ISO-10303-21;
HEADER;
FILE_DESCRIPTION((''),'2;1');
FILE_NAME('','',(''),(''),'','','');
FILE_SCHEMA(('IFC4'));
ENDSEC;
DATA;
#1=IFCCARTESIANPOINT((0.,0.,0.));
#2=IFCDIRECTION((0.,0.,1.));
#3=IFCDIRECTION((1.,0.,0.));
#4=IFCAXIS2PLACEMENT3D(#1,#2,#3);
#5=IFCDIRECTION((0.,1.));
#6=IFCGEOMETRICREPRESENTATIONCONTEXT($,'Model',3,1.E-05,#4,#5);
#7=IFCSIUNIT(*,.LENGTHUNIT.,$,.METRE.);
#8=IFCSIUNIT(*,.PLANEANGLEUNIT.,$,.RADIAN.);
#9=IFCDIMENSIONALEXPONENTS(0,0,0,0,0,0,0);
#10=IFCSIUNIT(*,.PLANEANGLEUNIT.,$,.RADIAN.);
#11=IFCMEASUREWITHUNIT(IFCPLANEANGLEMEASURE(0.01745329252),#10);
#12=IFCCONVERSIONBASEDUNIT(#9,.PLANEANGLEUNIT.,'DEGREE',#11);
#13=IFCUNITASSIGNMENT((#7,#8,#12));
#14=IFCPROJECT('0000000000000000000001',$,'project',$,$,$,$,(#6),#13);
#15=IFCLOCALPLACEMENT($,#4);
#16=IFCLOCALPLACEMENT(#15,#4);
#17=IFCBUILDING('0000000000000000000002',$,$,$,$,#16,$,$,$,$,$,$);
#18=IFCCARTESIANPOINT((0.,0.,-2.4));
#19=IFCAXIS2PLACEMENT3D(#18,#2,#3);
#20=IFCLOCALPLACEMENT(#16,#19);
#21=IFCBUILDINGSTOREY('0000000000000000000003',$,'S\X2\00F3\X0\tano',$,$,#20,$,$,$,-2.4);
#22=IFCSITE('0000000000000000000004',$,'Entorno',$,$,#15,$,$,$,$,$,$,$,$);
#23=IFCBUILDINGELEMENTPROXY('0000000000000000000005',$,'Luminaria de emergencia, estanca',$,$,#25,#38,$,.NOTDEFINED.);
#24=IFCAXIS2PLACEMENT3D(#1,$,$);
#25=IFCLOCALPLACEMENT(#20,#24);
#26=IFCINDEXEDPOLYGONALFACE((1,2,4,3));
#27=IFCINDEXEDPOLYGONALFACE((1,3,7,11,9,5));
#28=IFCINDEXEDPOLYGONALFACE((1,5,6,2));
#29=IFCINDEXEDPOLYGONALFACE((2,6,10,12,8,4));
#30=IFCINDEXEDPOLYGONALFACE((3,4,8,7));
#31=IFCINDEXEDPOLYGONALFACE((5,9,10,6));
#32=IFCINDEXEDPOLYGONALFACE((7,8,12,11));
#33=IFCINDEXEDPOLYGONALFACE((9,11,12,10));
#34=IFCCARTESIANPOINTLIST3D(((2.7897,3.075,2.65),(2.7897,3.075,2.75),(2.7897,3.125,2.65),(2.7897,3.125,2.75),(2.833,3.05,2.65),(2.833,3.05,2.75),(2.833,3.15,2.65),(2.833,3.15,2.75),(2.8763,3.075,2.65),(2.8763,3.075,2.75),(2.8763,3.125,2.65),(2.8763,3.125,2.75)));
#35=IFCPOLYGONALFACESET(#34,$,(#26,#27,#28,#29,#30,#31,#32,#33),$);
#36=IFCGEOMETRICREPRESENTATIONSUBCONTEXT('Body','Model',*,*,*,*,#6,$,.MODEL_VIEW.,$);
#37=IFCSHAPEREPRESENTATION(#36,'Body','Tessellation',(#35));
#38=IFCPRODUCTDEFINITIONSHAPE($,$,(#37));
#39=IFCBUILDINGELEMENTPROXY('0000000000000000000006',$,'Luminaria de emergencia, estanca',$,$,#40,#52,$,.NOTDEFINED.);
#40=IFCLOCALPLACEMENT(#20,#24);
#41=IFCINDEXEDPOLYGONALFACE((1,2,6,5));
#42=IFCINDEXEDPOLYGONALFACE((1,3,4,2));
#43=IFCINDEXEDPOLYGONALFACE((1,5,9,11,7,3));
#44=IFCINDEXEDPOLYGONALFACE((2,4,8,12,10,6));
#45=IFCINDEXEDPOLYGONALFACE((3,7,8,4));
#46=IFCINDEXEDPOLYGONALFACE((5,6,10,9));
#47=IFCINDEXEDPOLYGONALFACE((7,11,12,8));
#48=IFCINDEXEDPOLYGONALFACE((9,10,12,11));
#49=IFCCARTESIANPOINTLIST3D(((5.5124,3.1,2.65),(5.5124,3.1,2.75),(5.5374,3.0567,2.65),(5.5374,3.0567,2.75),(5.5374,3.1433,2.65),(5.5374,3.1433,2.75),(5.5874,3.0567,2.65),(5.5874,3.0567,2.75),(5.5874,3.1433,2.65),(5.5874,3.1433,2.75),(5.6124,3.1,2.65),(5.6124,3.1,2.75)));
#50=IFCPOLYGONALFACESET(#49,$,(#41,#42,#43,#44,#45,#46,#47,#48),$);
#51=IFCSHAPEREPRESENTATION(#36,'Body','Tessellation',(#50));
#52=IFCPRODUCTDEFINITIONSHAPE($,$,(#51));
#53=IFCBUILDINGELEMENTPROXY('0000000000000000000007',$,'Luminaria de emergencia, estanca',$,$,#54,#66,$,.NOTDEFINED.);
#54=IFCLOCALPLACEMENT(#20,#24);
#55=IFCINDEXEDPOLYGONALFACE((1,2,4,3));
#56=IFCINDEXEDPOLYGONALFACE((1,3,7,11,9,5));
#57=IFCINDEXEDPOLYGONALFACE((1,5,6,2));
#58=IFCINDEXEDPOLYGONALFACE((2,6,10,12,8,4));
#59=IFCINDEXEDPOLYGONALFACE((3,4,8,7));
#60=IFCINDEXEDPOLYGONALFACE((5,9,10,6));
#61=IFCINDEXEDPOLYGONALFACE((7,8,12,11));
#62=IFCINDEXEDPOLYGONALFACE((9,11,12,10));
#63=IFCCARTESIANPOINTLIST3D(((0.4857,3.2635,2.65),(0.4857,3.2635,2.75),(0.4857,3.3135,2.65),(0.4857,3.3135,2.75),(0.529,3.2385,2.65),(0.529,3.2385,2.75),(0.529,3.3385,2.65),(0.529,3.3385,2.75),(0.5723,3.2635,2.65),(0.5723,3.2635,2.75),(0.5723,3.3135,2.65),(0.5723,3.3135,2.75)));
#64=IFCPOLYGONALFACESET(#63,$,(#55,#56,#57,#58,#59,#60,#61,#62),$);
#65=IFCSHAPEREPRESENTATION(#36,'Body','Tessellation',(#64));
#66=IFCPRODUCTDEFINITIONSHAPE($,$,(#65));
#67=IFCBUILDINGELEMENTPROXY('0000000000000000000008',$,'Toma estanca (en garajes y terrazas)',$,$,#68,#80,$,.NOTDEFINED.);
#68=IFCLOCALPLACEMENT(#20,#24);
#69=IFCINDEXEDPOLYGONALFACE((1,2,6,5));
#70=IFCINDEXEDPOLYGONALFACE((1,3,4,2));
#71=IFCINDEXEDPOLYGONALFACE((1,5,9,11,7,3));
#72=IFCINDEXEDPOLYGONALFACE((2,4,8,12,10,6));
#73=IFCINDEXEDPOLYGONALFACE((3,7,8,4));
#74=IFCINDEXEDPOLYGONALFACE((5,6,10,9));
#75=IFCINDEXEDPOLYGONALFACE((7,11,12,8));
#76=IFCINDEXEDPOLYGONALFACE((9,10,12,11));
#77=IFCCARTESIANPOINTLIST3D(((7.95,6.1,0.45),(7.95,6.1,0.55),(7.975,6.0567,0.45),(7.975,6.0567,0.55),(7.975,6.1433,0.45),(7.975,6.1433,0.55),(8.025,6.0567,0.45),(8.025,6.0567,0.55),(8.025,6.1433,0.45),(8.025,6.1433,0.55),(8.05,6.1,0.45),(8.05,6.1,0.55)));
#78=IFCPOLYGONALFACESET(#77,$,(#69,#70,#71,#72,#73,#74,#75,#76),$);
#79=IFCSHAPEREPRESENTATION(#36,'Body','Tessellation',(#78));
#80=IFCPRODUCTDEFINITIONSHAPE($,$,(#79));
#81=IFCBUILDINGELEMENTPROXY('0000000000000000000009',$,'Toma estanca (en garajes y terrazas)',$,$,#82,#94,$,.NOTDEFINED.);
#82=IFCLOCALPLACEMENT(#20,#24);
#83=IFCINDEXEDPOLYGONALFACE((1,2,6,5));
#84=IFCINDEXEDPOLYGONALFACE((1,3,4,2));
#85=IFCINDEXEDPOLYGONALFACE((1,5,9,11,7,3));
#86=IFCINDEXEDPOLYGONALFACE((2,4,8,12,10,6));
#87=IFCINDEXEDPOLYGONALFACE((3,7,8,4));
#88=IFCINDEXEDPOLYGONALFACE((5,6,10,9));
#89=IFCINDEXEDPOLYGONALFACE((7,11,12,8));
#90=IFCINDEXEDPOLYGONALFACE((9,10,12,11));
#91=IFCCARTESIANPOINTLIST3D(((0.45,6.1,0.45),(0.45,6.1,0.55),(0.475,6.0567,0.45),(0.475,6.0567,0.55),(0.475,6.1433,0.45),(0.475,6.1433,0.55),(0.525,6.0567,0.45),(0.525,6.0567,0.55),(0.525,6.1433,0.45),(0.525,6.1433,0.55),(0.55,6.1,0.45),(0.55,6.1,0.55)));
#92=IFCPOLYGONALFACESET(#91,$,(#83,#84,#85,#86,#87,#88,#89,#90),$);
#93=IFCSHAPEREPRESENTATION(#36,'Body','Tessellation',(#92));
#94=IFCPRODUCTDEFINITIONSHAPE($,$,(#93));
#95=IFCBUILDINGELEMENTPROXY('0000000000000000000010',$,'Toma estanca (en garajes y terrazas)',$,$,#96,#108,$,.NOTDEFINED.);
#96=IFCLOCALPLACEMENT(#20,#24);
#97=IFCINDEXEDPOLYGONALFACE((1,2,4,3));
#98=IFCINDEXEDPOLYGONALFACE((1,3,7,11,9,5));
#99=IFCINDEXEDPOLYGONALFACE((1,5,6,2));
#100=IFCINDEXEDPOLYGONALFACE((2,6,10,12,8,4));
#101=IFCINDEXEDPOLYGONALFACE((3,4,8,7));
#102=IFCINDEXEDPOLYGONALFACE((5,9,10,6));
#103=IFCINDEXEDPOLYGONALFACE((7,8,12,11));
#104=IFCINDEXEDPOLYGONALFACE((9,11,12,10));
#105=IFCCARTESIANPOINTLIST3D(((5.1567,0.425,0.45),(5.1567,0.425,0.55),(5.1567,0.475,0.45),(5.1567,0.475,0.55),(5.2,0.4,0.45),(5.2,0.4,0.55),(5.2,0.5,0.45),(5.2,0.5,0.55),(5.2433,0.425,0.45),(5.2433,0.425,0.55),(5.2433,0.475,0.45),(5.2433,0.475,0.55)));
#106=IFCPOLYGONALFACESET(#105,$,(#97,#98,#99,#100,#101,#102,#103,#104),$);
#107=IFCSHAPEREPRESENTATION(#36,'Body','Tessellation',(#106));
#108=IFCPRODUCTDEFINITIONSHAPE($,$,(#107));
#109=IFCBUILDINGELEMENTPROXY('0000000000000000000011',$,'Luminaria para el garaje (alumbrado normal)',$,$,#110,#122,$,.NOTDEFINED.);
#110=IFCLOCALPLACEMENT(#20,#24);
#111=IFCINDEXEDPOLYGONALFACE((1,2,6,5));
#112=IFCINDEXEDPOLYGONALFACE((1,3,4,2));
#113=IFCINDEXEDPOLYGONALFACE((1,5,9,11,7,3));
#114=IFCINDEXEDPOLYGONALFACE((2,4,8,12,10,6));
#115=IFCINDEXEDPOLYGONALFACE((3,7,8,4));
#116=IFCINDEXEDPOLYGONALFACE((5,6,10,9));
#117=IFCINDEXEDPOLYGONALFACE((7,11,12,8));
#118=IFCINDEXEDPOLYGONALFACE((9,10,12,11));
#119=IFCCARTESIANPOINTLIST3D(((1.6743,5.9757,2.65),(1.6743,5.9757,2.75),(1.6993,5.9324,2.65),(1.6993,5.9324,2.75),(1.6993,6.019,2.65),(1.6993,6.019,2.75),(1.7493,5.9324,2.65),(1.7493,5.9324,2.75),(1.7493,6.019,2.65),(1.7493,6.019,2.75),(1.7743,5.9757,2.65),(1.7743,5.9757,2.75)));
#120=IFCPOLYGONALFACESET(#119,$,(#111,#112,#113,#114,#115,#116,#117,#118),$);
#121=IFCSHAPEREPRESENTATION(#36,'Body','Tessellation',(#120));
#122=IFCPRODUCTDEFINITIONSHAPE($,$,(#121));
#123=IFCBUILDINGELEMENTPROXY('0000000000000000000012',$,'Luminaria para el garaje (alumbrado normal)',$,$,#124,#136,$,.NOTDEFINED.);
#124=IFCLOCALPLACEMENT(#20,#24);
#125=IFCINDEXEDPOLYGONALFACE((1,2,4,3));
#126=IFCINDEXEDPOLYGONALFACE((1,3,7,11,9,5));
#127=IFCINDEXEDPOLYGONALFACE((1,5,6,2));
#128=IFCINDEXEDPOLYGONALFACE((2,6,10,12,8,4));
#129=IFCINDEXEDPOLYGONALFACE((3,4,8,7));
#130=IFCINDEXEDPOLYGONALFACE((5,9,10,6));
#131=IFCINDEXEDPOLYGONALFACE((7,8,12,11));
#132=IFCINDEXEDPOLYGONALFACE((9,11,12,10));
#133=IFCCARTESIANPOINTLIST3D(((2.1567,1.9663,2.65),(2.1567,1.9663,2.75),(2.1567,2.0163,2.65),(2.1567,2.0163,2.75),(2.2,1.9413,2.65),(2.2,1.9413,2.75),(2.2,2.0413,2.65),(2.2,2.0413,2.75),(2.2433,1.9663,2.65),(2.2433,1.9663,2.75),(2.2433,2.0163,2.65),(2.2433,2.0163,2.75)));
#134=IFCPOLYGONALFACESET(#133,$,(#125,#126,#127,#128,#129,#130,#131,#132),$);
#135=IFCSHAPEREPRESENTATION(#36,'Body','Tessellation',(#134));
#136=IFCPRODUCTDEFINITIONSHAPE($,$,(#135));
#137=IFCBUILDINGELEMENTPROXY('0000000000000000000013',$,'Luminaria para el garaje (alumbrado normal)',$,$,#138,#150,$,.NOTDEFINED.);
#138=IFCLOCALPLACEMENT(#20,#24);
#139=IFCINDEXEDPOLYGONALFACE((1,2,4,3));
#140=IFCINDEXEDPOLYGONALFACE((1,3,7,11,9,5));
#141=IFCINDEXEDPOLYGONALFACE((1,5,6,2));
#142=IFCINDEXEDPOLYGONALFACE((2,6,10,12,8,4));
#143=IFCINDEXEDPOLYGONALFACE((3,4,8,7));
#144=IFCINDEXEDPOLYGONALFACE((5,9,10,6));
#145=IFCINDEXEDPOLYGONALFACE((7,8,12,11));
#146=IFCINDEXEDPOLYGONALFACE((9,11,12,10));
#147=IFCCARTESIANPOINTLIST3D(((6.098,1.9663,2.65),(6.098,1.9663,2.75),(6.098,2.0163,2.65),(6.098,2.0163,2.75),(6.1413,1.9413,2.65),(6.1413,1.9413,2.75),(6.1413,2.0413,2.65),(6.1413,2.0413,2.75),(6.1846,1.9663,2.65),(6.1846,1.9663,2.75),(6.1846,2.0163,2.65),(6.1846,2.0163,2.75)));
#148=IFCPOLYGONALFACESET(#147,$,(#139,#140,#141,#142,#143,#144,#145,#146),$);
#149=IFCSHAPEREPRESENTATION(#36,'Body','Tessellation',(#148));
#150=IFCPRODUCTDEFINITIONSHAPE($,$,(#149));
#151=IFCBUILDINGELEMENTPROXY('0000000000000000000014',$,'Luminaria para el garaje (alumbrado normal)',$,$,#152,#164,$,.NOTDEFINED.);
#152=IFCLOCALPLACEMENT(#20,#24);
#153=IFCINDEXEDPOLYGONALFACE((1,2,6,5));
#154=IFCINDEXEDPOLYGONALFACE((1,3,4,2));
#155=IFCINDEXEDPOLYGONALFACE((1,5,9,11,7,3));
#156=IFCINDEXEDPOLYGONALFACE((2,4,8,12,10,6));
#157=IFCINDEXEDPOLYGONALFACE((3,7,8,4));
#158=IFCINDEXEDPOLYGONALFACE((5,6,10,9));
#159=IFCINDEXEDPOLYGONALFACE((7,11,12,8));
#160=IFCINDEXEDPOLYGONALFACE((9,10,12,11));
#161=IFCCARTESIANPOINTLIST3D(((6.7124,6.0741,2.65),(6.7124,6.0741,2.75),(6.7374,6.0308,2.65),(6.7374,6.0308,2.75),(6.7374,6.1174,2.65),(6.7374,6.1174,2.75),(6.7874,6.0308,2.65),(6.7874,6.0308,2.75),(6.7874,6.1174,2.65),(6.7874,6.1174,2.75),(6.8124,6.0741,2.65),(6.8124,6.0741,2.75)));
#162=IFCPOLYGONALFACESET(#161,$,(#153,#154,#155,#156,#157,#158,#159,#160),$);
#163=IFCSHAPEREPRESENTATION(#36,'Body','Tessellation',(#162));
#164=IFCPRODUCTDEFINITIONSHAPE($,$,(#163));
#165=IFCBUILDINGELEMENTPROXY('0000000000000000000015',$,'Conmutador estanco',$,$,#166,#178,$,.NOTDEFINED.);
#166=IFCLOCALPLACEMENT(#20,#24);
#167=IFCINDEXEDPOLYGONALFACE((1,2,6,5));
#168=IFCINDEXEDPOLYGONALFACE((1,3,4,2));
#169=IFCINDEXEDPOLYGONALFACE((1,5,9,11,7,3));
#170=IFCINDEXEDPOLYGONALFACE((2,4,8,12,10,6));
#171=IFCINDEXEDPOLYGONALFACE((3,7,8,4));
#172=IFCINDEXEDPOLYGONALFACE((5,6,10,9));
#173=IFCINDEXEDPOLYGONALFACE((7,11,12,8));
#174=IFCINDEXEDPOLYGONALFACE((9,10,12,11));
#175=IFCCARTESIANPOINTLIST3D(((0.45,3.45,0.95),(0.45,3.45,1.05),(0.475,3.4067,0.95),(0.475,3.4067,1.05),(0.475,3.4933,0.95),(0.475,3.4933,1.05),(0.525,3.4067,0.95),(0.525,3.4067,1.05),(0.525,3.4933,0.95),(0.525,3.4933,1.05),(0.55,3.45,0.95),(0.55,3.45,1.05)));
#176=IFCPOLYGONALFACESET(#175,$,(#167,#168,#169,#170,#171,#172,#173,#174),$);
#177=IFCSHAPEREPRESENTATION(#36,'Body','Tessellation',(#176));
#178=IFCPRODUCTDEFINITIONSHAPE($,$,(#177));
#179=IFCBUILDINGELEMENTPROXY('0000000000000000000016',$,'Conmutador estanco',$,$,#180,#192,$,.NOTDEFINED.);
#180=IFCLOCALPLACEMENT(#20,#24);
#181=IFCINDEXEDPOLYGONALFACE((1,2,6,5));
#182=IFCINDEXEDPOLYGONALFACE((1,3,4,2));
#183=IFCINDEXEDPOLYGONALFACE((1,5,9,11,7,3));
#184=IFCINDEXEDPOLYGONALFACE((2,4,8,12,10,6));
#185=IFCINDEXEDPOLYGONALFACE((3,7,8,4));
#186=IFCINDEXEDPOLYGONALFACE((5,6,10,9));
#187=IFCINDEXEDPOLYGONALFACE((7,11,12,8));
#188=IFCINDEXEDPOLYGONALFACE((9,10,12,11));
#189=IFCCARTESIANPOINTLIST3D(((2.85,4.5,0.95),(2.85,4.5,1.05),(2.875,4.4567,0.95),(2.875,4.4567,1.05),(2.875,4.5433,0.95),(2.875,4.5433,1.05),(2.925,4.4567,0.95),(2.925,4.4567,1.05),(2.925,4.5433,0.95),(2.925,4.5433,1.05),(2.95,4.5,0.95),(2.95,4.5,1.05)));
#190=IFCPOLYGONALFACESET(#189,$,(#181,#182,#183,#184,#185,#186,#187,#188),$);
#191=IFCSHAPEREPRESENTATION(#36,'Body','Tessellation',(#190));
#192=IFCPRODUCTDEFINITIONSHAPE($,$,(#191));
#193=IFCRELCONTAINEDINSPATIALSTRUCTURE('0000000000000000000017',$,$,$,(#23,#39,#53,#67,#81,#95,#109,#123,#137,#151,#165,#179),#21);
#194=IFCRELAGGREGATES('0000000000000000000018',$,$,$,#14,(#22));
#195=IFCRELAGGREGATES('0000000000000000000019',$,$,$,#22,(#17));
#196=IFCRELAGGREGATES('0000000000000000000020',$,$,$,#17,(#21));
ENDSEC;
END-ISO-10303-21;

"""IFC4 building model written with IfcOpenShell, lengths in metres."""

from ifc_helpers import new_model, entity, si_unit, converted_unit, direction, frame, origin_with_axes, place, context, subcontext, project, spatial, polyline, outline, extrude, source, transform, mapped, element, save


model = new_model("IFC4")

# Units and contexts
model_context = context("Model", 3, precision=1e-05, world=origin_with_axes(), true_north=direction((0.0, 1.0)))
body_context = subcontext(model_context, "Body", "Model", "MODEL_VIEW")
ifc_project = project(units=[si_unit("LENGTHUNIT", "METRE"), si_unit("PLANEANGLEUNIT", "RADIAN"), converted_unit("PLANEANGLEUNIT", "DEGREE", entity("IfcPlaneAngleMeasure", 0.01745329252), si_unit("PLANEANGLEUNIT", "RADIAN"), dimensions=[0, 0, 0, 0, 0, 0, 0])], contexts=[model_context])

# Site, building, storey
site_placement = place(None, origin_with_axes())
site = spatial("IfcSite", under=ifc_project, at=site_placement, Name="Entorno")
building_placement = place(site_placement, origin_with_axes())
building = spatial("IfcBuilding", under=site, at=building_placement)
storey_placement = place(building_placement, frame((0.0, 0.0, -2.4), z_axis=(0.0, 0.0, 1.0), x_axis=(1.0, 0.0, 0.0)))
storey = spatial("IfcBuildingStorey", under=building, at=storey_placement, Name="Sótano", Elevation=-2.4)

# Building element proxies
shared_shape_1 = source(origin_with_axes(), body_context, "Body", "SolidModel", [
    extrude(outline(polyline([(0.05, 0.0), (0.025, 0.0433), (-0.025, 0.0433), (-0.05, 0.0), (-0.025, -0.0433), (0.025, -0.0433), (0.05, 0.0)])), frame((0.0, 0.0, -0.05), z_axis=(0.0, 0.0, 1.0), x_axis=(1.0, 0.0, 0.0)), (0.0, 0.0, 1.0), 0.1),
])
proxy_1_placement = place(storey_placement, frame((0.0, 0.0, 2.4), z_axis=(0.0, 0.0, 1.0), x_axis=(1.0, 0.0, 0.0)))
element("IfcBuildingElementProxy", 1, at=proxy_1_placement, inside=storey, Name="Luminaria de emergencia, estanca", PredefinedType="NOTDEFINED", context=body_context, shape_type="Brep", body=[
    mapped(shared_shape_1, transform((2.833, 3.1, 0.3), x_axis=(0.0, 1.0, 0.0), y_axis=(-1.0, 0.0, 0.0), z_axis=(0.0, 0.0, 1.0))),
])
proxy_2_placement = place(storey_placement, frame((0.0, 0.0, 2.4), z_axis=(0.0, 0.0, 1.0), x_axis=(1.0, 0.0, 0.0)))
element("IfcBuildingElementProxy", 2, at=proxy_2_placement, inside=storey, Name="Luminaria de emergencia, estanca", PredefinedType="NOTDEFINED", context=body_context, shape_type="Brep", body=[
    mapped(shared_shape_1, transform((5.5624, 3.1, 0.3), x_axis=(-1.0, 0.0, 0.0), y_axis=(0.0, -1.0, 0.0), z_axis=(0.0, 0.0, 1.0))),
])
proxy_3_placement = place(storey_placement, frame((0.0, 0.0, 2.4), z_axis=(0.0, 0.0, 1.0), x_axis=(1.0, 0.0, 0.0)))
element("IfcBuildingElementProxy", 3, at=proxy_3_placement, inside=storey, Name="Luminaria de emergencia, estanca", PredefinedType="NOTDEFINED", context=body_context, shape_type="Brep", body=[
    mapped(shared_shape_1, transform((0.529, 3.2885, 0.3), x_axis=(0.0, 1.0, 0.0), y_axis=(-1.0, 0.0, 0.0), z_axis=(0.0, 0.0, 1.0))),
])
shared_shape_2 = source(origin_with_axes(), body_context, "Body", "SolidModel", [
    extrude(outline(polyline([(0.05, 0.0), (0.025, 0.0433), (-0.025, 0.0433), (-0.05, 0.0), (-0.025, -0.0433), (0.025, -0.0433), (0.05, 0.0)])), frame((0.0, 0.0, -0.05), z_axis=(0.0, 0.0, 1.0), x_axis=(1.0, 0.0, 0.0)), (0.0, 0.0, 1.0), 0.1),
])
proxy_4_placement = place(storey_placement, frame((0.0, 0.0, 2.4), z_axis=(0.0, 0.0, 1.0), x_axis=(1.0, 0.0, 0.0)))
element("IfcBuildingElementProxy", 4, at=proxy_4_placement, inside=storey, Name="Toma estanca (en garajes y terrazas)", PredefinedType="NOTDEFINED", context=body_context, shape_type="Brep", body=[
    mapped(shared_shape_2, transform((8.0, 6.1, -1.9), x_axis=(1.0, 0.0, 0.0), y_axis=(0.0, 1.0, 0.0), z_axis=(0.0, 0.0, 1.0))),
])
proxy_5_placement = place(storey_placement, frame((0.0, 0.0, 2.4), z_axis=(0.0, 0.0, 1.0), x_axis=(1.0, 0.0, 0.0)))
element("IfcBuildingElementProxy", 5, at=proxy_5_placement, inside=storey, Name="Toma estanca (en garajes y terrazas)", PredefinedType="NOTDEFINED", context=body_context, shape_type="Brep", body=[
    mapped(shared_shape_2, transform((0.5, 6.1, -1.9), x_axis=(-1.0, 0.0, 0.0), y_axis=(0.0, -1.0, 0.0), z_axis=(0.0, 0.0, 1.0))),
])
proxy_6_placement = place(storey_placement, frame((0.0, 0.0, 2.4), z_axis=(0.0, 0.0, 1.0), x_axis=(1.0, 0.0, 0.0)))
element("IfcBuildingElementProxy", 6, at=proxy_6_placement, inside=storey, Name="Toma estanca (en garajes y terrazas)", PredefinedType="NOTDEFINED", context=body_context, shape_type="Brep", body=[
    mapped(shared_shape_2, transform((5.2, 0.45, -1.9), x_axis=(0.0, -1.0, 0.0), y_axis=(1.0, 0.0, 0.0), z_axis=(0.0, 0.0, 1.0))),
])
shared_shape_3 = source(origin_with_axes(), body_context, "Body", "SolidModel", [
    extrude(outline(polyline([(0.05, 0.0), (0.025, 0.0433), (-0.025, 0.0433), (-0.05, 0.0), (-0.025, -0.0433), (0.025, -0.0433), (0.05, 0.0)])), frame((0.0, 0.0, -0.05), z_axis=(0.0, 0.0, 1.0), x_axis=(1.0, 0.0, 0.0)), (0.0, 0.0, 1.0), 0.1),
])
proxy_7_placement = place(storey_placement, frame((0.0, 0.0, 2.4), z_axis=(0.0, 0.0, 1.0), x_axis=(1.0, 0.0, 0.0)))
element("IfcBuildingElementProxy", 7, at=proxy_7_placement, inside=storey, Name="Luminaria para el garaje (alumbrado normal)", PredefinedType="NOTDEFINED", context=body_context, shape_type="Brep", body=[
    mapped(shared_shape_3, transform((1.7243, 5.9757, 0.3), x_axis=(1.0, 0.0, 0.0), y_axis=(0.0, 1.0, 0.0), z_axis=(0.0, 0.0, 1.0))),
])
proxy_8_placement = place(storey_placement, frame((0.0, 0.0, 2.4), z_axis=(0.0, 0.0, 1.0), x_axis=(1.0, 0.0, 0.0)))
element("IfcBuildingElementProxy", 8, at=proxy_8_placement, inside=storey, Name="Luminaria para el garaje (alumbrado normal)", PredefinedType="NOTDEFINED", context=body_context, shape_type="Brep", body=[
    mapped(shared_shape_3, transform((2.2, 1.9913, 0.3), x_axis=(0.0, 1.0, 0.0), y_axis=(-1.0, 0.0, 0.0), z_axis=(0.0, 0.0, 1.0))),
])
proxy_9_placement = place(storey_placement, frame((0.0, 0.0, 2.4), z_axis=(0.0, 0.0, 1.0), x_axis=(1.0, 0.0, 0.0)))
element("IfcBuildingElementProxy", 9, at=proxy_9_placement, inside=storey, Name="Luminaria para el garaje (alumbrado normal)", PredefinedType="NOTDEFINED", context=body_context, shape_type="Brep", body=[
    mapped(shared_shape_3, transform((6.1413, 1.9913, 0.3), x_axis=(0.0, 1.0, 0.0), y_axis=(-1.0, 0.0, 0.0), z_axis=(0.0, 0.0, 1.0))),
])
proxy_10_placement = place(storey_placement, frame((0.0, 0.0, 2.4), z_axis=(0.0, 0.0, 1.0), x_axis=(1.0, 0.0, 0.0)))
element("IfcBuildingElementProxy", 10, at=proxy_10_placement, inside=storey, Name="Luminaria para el garaje (alumbrado normal)", PredefinedType="NOTDEFINED", context=body_context, shape_type="Brep", body=[
    mapped(shared_shape_3, transform((6.7623, 6.0741, 0.3), x_axis=(-1.0, 0.0, 0.0), y_axis=(0.0, -1.0, 0.0), z_axis=(0.0, 0.0, 1.0))),
])
shared_shape_4 = source(origin_with_axes(), body_context, "Body", "SolidModel", [
    extrude(outline(polyline([(0.05, 0.0), (0.025, 0.0433), (-0.025, 0.0433), (-0.05, 0.0), (-0.025, -0.0433), (0.025, -0.0433), (0.05, 0.0)])), frame((0.0, 0.0, -0.05), z_axis=(0.0, 0.0, 1.0), x_axis=(1.0, 0.0, 0.0)), (0.0, 0.0, 1.0), 0.1),
])
proxy_11_placement = place(storey_placement, frame((0.0, 0.0, 2.4), z_axis=(0.0, 0.0, 1.0), x_axis=(1.0, 0.0, 0.0)))
element("IfcBuildingElementProxy", 11, at=proxy_11_placement, inside=storey, Name="Conmutador estanco", PredefinedType="NOTDEFINED", context=body_context, shape_type="Brep", body=[
    mapped(shared_shape_4, transform((0.5, 3.45, -1.4), x_axis=(1.0, 0.0, 0.0), y_axis=(0.0, 1.0, 0.0), z_axis=(0.0, 0.0, 1.0))),
])
proxy_12_placement = place(storey_placement, frame((0.0, 0.0, 2.4), z_axis=(0.0, 0.0, 1.0), x_axis=(1.0, 0.0, 0.0)))
element("IfcBuildingElementProxy", 12, at=proxy_12_placement, inside=storey, Name="Conmutador estanco", PredefinedType="NOTDEFINED", context=body_context, shape_type="Brep", body=[
    mapped(shared_shape_4, transform((2.9, 4.5, -1.4), x_axis=(1.0, 0.0, 0.0), y_axis=(0.0, 1.0, 0.0), z_axis=(0.0, 0.0, 1.0))),
])

save(model, "model.ifc")
